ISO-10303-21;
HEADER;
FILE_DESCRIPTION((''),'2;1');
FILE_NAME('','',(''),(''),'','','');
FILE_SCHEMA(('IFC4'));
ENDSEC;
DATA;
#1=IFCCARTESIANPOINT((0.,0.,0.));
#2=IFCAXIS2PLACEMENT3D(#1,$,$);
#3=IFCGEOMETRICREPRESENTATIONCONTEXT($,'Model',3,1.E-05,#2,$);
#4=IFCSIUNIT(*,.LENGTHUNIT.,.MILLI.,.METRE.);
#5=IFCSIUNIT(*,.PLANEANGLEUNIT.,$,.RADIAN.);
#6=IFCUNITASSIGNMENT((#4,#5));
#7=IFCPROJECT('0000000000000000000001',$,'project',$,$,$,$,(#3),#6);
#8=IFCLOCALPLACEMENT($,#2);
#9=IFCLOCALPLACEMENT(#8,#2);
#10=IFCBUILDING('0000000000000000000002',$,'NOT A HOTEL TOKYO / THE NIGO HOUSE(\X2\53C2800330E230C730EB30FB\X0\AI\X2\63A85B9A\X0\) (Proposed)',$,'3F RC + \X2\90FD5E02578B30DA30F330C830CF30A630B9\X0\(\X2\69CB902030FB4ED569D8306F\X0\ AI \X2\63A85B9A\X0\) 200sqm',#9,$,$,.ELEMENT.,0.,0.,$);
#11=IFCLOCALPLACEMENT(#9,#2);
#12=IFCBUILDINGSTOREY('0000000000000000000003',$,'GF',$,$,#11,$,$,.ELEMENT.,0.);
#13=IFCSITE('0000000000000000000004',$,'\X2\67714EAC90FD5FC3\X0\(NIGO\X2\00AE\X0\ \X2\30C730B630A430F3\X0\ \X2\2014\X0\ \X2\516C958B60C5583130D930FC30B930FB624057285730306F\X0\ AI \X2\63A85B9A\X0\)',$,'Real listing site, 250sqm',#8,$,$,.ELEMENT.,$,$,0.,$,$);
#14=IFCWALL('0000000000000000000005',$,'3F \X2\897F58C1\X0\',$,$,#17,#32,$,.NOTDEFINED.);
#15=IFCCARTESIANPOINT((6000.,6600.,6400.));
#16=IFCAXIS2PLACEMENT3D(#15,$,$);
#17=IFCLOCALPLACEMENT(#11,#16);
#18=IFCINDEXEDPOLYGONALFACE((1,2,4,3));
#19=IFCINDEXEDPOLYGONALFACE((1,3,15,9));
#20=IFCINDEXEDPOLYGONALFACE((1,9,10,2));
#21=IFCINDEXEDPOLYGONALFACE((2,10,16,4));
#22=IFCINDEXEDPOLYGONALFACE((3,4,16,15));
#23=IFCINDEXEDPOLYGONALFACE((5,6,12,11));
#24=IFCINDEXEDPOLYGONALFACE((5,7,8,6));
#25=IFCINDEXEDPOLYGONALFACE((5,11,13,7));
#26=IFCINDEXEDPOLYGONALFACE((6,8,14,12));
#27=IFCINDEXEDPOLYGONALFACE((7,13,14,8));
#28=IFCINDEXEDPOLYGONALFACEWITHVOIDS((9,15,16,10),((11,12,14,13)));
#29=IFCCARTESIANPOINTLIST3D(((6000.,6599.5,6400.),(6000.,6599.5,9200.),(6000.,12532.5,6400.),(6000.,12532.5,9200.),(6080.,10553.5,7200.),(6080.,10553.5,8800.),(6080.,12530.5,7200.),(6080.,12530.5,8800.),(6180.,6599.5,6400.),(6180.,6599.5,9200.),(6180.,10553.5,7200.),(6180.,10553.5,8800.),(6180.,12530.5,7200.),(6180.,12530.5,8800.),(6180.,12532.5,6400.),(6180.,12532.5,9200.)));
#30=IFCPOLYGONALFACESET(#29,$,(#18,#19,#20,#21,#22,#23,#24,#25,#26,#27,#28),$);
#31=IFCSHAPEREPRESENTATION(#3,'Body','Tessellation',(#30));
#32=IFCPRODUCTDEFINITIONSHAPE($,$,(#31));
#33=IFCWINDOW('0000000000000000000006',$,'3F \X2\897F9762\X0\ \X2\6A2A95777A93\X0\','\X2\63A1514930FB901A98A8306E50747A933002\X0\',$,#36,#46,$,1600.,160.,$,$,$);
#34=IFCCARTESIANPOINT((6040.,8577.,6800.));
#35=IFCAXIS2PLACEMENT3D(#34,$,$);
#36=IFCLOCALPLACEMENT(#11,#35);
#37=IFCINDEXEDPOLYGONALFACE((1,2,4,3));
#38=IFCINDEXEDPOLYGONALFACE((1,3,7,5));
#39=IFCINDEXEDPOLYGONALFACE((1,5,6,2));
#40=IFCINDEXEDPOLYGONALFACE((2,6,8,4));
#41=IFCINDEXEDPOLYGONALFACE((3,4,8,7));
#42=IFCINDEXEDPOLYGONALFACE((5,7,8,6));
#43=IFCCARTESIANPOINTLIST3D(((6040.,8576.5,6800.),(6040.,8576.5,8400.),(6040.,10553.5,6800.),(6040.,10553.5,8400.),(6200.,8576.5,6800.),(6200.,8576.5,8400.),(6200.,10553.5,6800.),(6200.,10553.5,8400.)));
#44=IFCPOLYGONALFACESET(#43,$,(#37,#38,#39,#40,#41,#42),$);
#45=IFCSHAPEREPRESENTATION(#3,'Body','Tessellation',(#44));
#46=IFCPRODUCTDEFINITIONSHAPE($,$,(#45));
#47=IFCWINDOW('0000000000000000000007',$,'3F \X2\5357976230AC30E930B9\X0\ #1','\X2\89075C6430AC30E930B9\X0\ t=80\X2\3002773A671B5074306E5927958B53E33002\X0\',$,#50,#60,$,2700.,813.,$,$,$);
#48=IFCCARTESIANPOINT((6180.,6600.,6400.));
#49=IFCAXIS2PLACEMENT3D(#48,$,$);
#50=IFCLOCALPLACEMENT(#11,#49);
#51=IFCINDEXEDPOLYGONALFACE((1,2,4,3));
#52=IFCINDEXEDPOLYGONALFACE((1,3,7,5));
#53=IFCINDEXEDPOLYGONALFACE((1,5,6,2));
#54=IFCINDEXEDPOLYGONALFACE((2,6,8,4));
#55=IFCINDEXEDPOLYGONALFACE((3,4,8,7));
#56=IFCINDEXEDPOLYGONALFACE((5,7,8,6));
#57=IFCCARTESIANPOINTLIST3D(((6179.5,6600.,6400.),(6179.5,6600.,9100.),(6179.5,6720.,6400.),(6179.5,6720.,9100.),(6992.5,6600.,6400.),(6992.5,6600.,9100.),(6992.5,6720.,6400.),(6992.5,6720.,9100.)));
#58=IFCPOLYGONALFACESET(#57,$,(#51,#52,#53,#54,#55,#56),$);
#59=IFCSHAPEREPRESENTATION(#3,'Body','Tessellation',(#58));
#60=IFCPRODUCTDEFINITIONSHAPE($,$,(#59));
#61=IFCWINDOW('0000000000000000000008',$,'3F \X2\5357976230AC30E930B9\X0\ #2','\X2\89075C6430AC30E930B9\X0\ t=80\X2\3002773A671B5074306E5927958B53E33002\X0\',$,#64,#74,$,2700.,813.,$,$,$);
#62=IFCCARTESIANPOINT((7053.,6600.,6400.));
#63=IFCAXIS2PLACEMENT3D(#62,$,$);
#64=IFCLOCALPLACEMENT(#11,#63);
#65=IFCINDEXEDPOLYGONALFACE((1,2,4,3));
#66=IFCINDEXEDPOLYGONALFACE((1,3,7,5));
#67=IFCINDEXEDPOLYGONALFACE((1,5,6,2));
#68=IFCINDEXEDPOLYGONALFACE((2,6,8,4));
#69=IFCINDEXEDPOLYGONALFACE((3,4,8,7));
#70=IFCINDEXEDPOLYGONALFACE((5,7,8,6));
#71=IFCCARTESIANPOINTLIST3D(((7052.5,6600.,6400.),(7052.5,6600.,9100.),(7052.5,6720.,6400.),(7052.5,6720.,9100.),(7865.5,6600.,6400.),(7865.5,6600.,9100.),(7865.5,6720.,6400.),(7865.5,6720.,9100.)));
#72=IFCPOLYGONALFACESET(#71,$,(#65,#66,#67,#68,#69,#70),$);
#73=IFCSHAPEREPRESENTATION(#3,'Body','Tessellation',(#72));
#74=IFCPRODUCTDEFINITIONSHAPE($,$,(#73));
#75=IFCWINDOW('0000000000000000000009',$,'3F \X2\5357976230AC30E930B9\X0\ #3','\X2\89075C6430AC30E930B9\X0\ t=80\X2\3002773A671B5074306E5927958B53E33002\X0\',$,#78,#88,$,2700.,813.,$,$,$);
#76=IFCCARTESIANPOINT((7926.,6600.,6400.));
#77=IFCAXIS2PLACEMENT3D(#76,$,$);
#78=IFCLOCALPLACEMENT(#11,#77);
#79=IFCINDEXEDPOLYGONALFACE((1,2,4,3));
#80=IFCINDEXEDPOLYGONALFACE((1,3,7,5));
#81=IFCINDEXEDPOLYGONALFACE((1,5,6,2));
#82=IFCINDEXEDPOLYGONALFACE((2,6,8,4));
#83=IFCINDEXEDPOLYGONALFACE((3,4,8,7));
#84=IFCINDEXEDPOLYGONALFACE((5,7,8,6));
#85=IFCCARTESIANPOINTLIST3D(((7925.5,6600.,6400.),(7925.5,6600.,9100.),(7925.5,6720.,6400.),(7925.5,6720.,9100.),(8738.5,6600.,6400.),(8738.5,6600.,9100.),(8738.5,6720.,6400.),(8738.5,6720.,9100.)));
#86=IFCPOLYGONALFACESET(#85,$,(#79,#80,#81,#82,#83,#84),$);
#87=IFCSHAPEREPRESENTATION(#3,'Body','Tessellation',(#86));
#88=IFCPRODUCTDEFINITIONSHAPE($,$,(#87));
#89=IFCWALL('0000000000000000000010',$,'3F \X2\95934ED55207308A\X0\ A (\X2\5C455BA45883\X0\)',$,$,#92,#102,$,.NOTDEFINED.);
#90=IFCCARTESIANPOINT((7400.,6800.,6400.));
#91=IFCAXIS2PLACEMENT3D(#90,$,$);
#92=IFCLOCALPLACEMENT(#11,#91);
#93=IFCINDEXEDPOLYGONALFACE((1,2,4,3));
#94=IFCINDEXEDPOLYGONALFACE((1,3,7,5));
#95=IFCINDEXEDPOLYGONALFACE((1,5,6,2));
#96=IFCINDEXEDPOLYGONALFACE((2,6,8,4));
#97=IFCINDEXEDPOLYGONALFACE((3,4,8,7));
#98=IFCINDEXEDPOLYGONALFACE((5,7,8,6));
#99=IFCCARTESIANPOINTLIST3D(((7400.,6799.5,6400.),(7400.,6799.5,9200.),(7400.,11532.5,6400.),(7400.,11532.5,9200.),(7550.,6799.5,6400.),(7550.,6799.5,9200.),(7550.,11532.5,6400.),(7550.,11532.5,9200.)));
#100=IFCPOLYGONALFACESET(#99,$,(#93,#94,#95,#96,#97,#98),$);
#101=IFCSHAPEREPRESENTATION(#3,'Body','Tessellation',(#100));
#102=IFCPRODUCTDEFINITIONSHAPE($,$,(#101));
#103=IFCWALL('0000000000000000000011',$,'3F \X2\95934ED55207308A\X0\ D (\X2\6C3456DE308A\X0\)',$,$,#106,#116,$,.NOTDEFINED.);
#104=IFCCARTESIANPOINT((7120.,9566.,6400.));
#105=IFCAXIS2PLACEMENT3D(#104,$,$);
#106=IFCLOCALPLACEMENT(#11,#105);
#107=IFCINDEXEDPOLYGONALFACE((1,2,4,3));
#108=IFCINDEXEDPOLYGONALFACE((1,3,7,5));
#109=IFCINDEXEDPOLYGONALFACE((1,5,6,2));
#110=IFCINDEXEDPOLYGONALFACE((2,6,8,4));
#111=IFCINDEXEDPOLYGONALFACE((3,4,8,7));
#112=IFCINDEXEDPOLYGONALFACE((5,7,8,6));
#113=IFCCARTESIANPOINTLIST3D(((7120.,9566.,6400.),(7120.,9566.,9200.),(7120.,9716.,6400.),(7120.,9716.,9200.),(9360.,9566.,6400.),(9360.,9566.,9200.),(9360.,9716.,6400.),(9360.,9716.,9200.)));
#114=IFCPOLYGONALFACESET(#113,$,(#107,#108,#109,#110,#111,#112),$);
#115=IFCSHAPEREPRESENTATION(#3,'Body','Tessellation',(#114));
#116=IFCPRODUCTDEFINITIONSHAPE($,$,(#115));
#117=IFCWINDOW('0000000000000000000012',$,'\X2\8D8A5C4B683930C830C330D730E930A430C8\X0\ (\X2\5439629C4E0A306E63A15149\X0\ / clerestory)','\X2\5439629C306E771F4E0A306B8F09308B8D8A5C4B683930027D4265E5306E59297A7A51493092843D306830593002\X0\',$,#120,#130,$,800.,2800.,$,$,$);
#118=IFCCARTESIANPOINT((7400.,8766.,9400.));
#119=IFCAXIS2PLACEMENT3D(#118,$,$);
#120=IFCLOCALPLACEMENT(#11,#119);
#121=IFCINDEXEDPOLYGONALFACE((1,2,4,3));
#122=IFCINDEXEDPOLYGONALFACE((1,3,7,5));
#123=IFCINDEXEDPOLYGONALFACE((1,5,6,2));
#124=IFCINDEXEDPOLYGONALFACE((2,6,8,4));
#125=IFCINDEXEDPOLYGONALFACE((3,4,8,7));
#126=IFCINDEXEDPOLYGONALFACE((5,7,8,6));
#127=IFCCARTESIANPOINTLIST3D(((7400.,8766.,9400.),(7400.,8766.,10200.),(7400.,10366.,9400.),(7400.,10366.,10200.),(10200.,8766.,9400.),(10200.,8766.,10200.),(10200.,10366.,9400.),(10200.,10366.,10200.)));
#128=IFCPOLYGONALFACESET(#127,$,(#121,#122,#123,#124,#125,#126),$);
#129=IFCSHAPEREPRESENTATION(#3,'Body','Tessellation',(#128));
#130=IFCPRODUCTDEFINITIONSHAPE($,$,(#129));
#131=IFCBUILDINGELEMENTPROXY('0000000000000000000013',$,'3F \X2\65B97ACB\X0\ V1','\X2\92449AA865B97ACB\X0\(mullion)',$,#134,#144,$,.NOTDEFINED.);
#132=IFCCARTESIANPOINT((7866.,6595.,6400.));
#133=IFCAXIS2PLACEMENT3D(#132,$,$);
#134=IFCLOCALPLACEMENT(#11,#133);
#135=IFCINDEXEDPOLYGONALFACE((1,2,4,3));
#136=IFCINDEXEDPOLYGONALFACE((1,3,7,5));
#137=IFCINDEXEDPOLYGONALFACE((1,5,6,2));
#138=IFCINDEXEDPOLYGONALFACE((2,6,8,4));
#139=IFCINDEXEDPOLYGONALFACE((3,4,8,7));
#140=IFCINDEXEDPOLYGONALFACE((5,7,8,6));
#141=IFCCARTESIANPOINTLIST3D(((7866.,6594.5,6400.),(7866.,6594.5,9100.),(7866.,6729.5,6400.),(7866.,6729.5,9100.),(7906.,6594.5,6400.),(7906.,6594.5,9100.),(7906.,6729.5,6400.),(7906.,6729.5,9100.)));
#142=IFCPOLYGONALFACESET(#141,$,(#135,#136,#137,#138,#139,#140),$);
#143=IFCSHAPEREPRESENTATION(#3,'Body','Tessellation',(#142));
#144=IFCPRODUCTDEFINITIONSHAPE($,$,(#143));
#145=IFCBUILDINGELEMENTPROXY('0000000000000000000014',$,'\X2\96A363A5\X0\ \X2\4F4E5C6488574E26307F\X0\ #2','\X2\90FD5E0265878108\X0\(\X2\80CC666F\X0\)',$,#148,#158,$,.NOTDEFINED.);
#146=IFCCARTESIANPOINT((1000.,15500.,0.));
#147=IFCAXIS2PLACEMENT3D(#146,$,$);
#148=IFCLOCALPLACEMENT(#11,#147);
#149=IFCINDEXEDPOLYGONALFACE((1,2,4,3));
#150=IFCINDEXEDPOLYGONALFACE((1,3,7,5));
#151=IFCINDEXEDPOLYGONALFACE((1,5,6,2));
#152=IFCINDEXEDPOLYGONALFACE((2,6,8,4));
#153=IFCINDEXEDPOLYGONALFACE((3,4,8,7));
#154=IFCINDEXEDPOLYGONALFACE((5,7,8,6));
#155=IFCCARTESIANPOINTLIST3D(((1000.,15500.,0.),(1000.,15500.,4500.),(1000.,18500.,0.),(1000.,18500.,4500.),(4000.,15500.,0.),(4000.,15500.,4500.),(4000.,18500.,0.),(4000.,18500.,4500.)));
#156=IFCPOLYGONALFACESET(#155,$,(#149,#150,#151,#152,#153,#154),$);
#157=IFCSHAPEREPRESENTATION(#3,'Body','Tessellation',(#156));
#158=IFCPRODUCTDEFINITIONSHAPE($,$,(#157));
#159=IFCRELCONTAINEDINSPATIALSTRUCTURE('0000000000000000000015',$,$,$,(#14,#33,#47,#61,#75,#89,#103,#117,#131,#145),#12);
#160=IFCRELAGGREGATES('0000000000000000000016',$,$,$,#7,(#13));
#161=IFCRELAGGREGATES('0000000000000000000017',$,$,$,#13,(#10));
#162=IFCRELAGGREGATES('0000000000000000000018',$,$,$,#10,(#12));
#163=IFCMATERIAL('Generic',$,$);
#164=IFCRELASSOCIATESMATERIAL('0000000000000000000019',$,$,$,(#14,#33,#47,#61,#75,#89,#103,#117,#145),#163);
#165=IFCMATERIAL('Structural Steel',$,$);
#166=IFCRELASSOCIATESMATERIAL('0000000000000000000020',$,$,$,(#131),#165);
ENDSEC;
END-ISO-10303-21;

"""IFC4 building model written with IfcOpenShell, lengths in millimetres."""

from ifc_helpers import new_model, si_unit, frame, frame_2d, origin, place, context, project, spatial, rectangle, extrude, material, element, fill, save


model = new_model("IFC4")

# Units and contexts
model_context = context("Model", 3, precision=1e-05, world=origin())
ifc_project = project(units=[si_unit("LENGTHUNIT", "METRE", prefix="MILLI"), si_unit("PLANEANGLEUNIT", "RADIAN")], contexts=[model_context])

# Site, building, storey
site_placement = place(None, origin())
site = spatial("IfcSite", under=ifc_project, at=site_placement, Name="東京都心(NIGO® デザイン — 公開情報ベース・所在地は AI 推定)", ObjectType="Real listing site, 250sqm", CompositionType="ELEMENT", RefElevation=0.0)
building_placement = place(site_placement, origin())
building = spatial("IfcBuilding", under=site, at=building_placement, Name="NOT A HOTEL TOKYO / THE NIGO HOUSE(参考モデル・AI推定) (Proposed)", ObjectType="3F RC + 都市型ペントハウス(構造・仕様は AI 推定) 200sqm", CompositionType="ELEMENT", ElevationOfRefHeight=0.0, ElevationOfTerrain=0.0)
storey_placement = place(building_placement, origin())
storey = spatial("IfcBuildingStorey", under=building, at=storey_placement, Name="GF", CompositionType="ELEMENT", Elevation=0.0)

# Shared definitions
ifc_material_1 = material(Name="Generic")

# Wall, opening, window
wall_1_placement = place(storey_placement, frame((6000.0, 6600.0, 6400.0)))
wall_1 = element("IfcWall", 1, at=wall_1_placement, inside=storey, material=ifc_material_1, Name="3F 西壁", PredefinedType="NOTDEFINED", context=model_context, shape_type="SweptSolid", body=[
    extrude(rectangle(XDim=180.0, YDim=5933.0, at=frame_2d((90.0, 2966.0))), frame((6000.0, 6600.0, 6400.0)), (0.0, 0.0, 1.0), 2800.0),
])
opening_1_placement = place(storey_placement, frame((6040.0, 8577.0, 6800.0)))
opening_1 = element("IfcOpeningElement", 2, at=opening_1_placement, cuts=wall_1, PredefinedType="NOTDEFINED", context=model_context, shape_type="SweptSolid", body=[
    extrude(rectangle(XDim=160.0, YDim=1977.0, at=frame_2d((80.0, 988.0))), frame((6040.0, 8577.0, 6800.0)), (0.0, 0.0, 1.0), 1600.0),
])
window_1_placement = place(storey_placement, frame((6040.0, 8577.0, 6800.0)))
window_1 = element("IfcWindow", 3, at=window_1_placement, inside=storey, material=ifc_material_1, Name="3F 西面 横長窓", Description="採光・通風の側窓。", OverallHeight=1600.0, OverallWidth=160.0, context=model_context, shape_type="SweptSolid", body=[
    extrude(rectangle(XDim=160.0, YDim=1977.0, at=frame_2d((80.0, 988.0))), frame((6040.0, 8577.0, 6800.0)), (0.0, 0.0, 1.0), 1600.0),
])
fill(opening_1, window_1)

# Windows
window_2_placement = place(storey_placement, frame((6180.0, 6600.0, 6400.0)))
element("IfcWindow", 4, at=window_2_placement, inside=storey, material=ifc_material_1, Name="3F 南面ガラス #1", Description="複層ガラス t=80。眺望側の大開口。", OverallHeight=2700.0, OverallWidth=813.0, context=model_context, shape_type="SweptSolid", body=[
    extrude(rectangle(XDim=813.0, YDim=120.0, at=frame_2d((406.0, 60.0))), frame((6180.0, 6600.0, 6400.0)), (0.0, 0.0, 1.0), 2700.0),
])
window_3_placement = place(storey_placement, frame((7053.0, 6600.0, 6400.0)))
element("IfcWindow", 5, at=window_3_placement, inside=storey, material=ifc_material_1, Name="3F 南面ガラス #2", Description="複層ガラス t=80。眺望側の大開口。", OverallHeight=2700.0, OverallWidth=813.0, context=model_context, shape_type="SweptSolid", body=[
    extrude(rectangle(XDim=813.0, YDim=120.0, at=frame_2d((406.0, 60.0))), frame((7053.0, 6600.0, 6400.0)), (0.0, 0.0, 1.0), 2700.0),
])
window_4_placement = place(storey_placement, frame((7926.0, 6600.0, 6400.0)))
element("IfcWindow", 6, at=window_4_placement, inside=storey, material=ifc_material_1, Name="3F 南面ガラス #3", Description="複層ガラス t=80。眺望側の大開口。", OverallHeight=2700.0, OverallWidth=813.0, context=model_context, shape_type="SweptSolid", body=[
    extrude(rectangle(XDim=813.0, YDim=120.0, at=frame_2d((406.0, 60.0))), frame((7926.0, 6600.0, 6400.0)), (0.0, 0.0, 1.0), 2700.0),
])

# Walls
wall_2_placement = place(storey_placement, frame((7400.0, 6800.0, 6400.0)))
element("IfcWall", 7, at=wall_2_placement, inside=storey, material=ifc_material_1, Name="3F 間仕切り A (居室境)", PredefinedType="NOTDEFINED", context=model_context, shape_type="SweptSolid", body=[
    extrude(rectangle(XDim=150.0, YDim=4733.0, at=frame_2d((75.0, 2366.0))), frame((7400.0, 6800.0, 6400.0)), (0.0, 0.0, 1.0), 2800.0),
])
wall_3_placement = place(storey_placement, frame((7120.0, 9566.0, 6400.0)))
element("IfcWall", 8, at=wall_3_placement, inside=storey, material=ifc_material_1, Name="3F 間仕切り D (水回り)", PredefinedType="NOTDEFINED", context=model_context, shape_type="SweptSolid", body=[
    extrude(rectangle(XDim=2240.0, YDim=150.0, at=frame_2d((1120.0, 75.0))), frame((7120.0, 9566.0, 6400.0)), (0.0, 0.0, 1.0), 2800.0),
])

# Window
window_5_placement = place(storey_placement, frame((7400.0, 8766.0, 9400.0)))
element("IfcWindow", 9, at=window_5_placement, inside=storey, material=ifc_material_1, Name="越屋根トップライト (吹抜上の採光 / clerestory)", Description="吹抜の真上に載る越屋根。終日の天空光を落とす。", OverallHeight=800.0, OverallWidth=2800.0, context=model_context, shape_type="SweptSolid", body=[
    extrude(rectangle(XDim=2800.0, YDim=1600.0, at=frame_2d((1400.0, 800.0))), frame((7400.0, 8766.0, 9400.0)), (0.0, 0.0, 1.0), 800.0),
])

# Building element proxies
ifc_material_2 = material(Name="Structural Steel")
proxy_1_placement = place(storey_placement, frame((7866.0, 6595.0, 6400.0)))
element("IfcBuildingElementProxy", 10, at=proxy_1_placement, inside=storey, material=ifc_material_2, Name="3F 方立 V1", Description="鉄骨方立(mullion)", PredefinedType="NOTDEFINED", context=model_context, shape_type="SweptSolid", body=[
    extrude(rectangle(XDim=40.0, YDim=135.0, at=frame_2d((20.0, 67.0))), frame((7866.0, 6595.0, 6400.0)), (0.0, 0.0, 1.0), 2700.0),
])
proxy_2_placement = place(storey_placement, frame((1000.0, 15500.0, 0.0)))
element("IfcBuildingElementProxy", 11, at=proxy_2_placement, inside=storey, material=ifc_material_1, Name="隣接 低層街並み #2", Description="都市文脈(背景)", PredefinedType="NOTDEFINED", context=model_context, shape_type="SweptSolid", body=[
    extrude(rectangle(XDim=3000.0, YDim=3000.0, at=frame_2d((1500.0, 1500.0))), frame((1000.0, 15500.0, 0.0)), (0.0, 0.0, 1.0), 4500.0),
])

save(model, "model.ifc")
